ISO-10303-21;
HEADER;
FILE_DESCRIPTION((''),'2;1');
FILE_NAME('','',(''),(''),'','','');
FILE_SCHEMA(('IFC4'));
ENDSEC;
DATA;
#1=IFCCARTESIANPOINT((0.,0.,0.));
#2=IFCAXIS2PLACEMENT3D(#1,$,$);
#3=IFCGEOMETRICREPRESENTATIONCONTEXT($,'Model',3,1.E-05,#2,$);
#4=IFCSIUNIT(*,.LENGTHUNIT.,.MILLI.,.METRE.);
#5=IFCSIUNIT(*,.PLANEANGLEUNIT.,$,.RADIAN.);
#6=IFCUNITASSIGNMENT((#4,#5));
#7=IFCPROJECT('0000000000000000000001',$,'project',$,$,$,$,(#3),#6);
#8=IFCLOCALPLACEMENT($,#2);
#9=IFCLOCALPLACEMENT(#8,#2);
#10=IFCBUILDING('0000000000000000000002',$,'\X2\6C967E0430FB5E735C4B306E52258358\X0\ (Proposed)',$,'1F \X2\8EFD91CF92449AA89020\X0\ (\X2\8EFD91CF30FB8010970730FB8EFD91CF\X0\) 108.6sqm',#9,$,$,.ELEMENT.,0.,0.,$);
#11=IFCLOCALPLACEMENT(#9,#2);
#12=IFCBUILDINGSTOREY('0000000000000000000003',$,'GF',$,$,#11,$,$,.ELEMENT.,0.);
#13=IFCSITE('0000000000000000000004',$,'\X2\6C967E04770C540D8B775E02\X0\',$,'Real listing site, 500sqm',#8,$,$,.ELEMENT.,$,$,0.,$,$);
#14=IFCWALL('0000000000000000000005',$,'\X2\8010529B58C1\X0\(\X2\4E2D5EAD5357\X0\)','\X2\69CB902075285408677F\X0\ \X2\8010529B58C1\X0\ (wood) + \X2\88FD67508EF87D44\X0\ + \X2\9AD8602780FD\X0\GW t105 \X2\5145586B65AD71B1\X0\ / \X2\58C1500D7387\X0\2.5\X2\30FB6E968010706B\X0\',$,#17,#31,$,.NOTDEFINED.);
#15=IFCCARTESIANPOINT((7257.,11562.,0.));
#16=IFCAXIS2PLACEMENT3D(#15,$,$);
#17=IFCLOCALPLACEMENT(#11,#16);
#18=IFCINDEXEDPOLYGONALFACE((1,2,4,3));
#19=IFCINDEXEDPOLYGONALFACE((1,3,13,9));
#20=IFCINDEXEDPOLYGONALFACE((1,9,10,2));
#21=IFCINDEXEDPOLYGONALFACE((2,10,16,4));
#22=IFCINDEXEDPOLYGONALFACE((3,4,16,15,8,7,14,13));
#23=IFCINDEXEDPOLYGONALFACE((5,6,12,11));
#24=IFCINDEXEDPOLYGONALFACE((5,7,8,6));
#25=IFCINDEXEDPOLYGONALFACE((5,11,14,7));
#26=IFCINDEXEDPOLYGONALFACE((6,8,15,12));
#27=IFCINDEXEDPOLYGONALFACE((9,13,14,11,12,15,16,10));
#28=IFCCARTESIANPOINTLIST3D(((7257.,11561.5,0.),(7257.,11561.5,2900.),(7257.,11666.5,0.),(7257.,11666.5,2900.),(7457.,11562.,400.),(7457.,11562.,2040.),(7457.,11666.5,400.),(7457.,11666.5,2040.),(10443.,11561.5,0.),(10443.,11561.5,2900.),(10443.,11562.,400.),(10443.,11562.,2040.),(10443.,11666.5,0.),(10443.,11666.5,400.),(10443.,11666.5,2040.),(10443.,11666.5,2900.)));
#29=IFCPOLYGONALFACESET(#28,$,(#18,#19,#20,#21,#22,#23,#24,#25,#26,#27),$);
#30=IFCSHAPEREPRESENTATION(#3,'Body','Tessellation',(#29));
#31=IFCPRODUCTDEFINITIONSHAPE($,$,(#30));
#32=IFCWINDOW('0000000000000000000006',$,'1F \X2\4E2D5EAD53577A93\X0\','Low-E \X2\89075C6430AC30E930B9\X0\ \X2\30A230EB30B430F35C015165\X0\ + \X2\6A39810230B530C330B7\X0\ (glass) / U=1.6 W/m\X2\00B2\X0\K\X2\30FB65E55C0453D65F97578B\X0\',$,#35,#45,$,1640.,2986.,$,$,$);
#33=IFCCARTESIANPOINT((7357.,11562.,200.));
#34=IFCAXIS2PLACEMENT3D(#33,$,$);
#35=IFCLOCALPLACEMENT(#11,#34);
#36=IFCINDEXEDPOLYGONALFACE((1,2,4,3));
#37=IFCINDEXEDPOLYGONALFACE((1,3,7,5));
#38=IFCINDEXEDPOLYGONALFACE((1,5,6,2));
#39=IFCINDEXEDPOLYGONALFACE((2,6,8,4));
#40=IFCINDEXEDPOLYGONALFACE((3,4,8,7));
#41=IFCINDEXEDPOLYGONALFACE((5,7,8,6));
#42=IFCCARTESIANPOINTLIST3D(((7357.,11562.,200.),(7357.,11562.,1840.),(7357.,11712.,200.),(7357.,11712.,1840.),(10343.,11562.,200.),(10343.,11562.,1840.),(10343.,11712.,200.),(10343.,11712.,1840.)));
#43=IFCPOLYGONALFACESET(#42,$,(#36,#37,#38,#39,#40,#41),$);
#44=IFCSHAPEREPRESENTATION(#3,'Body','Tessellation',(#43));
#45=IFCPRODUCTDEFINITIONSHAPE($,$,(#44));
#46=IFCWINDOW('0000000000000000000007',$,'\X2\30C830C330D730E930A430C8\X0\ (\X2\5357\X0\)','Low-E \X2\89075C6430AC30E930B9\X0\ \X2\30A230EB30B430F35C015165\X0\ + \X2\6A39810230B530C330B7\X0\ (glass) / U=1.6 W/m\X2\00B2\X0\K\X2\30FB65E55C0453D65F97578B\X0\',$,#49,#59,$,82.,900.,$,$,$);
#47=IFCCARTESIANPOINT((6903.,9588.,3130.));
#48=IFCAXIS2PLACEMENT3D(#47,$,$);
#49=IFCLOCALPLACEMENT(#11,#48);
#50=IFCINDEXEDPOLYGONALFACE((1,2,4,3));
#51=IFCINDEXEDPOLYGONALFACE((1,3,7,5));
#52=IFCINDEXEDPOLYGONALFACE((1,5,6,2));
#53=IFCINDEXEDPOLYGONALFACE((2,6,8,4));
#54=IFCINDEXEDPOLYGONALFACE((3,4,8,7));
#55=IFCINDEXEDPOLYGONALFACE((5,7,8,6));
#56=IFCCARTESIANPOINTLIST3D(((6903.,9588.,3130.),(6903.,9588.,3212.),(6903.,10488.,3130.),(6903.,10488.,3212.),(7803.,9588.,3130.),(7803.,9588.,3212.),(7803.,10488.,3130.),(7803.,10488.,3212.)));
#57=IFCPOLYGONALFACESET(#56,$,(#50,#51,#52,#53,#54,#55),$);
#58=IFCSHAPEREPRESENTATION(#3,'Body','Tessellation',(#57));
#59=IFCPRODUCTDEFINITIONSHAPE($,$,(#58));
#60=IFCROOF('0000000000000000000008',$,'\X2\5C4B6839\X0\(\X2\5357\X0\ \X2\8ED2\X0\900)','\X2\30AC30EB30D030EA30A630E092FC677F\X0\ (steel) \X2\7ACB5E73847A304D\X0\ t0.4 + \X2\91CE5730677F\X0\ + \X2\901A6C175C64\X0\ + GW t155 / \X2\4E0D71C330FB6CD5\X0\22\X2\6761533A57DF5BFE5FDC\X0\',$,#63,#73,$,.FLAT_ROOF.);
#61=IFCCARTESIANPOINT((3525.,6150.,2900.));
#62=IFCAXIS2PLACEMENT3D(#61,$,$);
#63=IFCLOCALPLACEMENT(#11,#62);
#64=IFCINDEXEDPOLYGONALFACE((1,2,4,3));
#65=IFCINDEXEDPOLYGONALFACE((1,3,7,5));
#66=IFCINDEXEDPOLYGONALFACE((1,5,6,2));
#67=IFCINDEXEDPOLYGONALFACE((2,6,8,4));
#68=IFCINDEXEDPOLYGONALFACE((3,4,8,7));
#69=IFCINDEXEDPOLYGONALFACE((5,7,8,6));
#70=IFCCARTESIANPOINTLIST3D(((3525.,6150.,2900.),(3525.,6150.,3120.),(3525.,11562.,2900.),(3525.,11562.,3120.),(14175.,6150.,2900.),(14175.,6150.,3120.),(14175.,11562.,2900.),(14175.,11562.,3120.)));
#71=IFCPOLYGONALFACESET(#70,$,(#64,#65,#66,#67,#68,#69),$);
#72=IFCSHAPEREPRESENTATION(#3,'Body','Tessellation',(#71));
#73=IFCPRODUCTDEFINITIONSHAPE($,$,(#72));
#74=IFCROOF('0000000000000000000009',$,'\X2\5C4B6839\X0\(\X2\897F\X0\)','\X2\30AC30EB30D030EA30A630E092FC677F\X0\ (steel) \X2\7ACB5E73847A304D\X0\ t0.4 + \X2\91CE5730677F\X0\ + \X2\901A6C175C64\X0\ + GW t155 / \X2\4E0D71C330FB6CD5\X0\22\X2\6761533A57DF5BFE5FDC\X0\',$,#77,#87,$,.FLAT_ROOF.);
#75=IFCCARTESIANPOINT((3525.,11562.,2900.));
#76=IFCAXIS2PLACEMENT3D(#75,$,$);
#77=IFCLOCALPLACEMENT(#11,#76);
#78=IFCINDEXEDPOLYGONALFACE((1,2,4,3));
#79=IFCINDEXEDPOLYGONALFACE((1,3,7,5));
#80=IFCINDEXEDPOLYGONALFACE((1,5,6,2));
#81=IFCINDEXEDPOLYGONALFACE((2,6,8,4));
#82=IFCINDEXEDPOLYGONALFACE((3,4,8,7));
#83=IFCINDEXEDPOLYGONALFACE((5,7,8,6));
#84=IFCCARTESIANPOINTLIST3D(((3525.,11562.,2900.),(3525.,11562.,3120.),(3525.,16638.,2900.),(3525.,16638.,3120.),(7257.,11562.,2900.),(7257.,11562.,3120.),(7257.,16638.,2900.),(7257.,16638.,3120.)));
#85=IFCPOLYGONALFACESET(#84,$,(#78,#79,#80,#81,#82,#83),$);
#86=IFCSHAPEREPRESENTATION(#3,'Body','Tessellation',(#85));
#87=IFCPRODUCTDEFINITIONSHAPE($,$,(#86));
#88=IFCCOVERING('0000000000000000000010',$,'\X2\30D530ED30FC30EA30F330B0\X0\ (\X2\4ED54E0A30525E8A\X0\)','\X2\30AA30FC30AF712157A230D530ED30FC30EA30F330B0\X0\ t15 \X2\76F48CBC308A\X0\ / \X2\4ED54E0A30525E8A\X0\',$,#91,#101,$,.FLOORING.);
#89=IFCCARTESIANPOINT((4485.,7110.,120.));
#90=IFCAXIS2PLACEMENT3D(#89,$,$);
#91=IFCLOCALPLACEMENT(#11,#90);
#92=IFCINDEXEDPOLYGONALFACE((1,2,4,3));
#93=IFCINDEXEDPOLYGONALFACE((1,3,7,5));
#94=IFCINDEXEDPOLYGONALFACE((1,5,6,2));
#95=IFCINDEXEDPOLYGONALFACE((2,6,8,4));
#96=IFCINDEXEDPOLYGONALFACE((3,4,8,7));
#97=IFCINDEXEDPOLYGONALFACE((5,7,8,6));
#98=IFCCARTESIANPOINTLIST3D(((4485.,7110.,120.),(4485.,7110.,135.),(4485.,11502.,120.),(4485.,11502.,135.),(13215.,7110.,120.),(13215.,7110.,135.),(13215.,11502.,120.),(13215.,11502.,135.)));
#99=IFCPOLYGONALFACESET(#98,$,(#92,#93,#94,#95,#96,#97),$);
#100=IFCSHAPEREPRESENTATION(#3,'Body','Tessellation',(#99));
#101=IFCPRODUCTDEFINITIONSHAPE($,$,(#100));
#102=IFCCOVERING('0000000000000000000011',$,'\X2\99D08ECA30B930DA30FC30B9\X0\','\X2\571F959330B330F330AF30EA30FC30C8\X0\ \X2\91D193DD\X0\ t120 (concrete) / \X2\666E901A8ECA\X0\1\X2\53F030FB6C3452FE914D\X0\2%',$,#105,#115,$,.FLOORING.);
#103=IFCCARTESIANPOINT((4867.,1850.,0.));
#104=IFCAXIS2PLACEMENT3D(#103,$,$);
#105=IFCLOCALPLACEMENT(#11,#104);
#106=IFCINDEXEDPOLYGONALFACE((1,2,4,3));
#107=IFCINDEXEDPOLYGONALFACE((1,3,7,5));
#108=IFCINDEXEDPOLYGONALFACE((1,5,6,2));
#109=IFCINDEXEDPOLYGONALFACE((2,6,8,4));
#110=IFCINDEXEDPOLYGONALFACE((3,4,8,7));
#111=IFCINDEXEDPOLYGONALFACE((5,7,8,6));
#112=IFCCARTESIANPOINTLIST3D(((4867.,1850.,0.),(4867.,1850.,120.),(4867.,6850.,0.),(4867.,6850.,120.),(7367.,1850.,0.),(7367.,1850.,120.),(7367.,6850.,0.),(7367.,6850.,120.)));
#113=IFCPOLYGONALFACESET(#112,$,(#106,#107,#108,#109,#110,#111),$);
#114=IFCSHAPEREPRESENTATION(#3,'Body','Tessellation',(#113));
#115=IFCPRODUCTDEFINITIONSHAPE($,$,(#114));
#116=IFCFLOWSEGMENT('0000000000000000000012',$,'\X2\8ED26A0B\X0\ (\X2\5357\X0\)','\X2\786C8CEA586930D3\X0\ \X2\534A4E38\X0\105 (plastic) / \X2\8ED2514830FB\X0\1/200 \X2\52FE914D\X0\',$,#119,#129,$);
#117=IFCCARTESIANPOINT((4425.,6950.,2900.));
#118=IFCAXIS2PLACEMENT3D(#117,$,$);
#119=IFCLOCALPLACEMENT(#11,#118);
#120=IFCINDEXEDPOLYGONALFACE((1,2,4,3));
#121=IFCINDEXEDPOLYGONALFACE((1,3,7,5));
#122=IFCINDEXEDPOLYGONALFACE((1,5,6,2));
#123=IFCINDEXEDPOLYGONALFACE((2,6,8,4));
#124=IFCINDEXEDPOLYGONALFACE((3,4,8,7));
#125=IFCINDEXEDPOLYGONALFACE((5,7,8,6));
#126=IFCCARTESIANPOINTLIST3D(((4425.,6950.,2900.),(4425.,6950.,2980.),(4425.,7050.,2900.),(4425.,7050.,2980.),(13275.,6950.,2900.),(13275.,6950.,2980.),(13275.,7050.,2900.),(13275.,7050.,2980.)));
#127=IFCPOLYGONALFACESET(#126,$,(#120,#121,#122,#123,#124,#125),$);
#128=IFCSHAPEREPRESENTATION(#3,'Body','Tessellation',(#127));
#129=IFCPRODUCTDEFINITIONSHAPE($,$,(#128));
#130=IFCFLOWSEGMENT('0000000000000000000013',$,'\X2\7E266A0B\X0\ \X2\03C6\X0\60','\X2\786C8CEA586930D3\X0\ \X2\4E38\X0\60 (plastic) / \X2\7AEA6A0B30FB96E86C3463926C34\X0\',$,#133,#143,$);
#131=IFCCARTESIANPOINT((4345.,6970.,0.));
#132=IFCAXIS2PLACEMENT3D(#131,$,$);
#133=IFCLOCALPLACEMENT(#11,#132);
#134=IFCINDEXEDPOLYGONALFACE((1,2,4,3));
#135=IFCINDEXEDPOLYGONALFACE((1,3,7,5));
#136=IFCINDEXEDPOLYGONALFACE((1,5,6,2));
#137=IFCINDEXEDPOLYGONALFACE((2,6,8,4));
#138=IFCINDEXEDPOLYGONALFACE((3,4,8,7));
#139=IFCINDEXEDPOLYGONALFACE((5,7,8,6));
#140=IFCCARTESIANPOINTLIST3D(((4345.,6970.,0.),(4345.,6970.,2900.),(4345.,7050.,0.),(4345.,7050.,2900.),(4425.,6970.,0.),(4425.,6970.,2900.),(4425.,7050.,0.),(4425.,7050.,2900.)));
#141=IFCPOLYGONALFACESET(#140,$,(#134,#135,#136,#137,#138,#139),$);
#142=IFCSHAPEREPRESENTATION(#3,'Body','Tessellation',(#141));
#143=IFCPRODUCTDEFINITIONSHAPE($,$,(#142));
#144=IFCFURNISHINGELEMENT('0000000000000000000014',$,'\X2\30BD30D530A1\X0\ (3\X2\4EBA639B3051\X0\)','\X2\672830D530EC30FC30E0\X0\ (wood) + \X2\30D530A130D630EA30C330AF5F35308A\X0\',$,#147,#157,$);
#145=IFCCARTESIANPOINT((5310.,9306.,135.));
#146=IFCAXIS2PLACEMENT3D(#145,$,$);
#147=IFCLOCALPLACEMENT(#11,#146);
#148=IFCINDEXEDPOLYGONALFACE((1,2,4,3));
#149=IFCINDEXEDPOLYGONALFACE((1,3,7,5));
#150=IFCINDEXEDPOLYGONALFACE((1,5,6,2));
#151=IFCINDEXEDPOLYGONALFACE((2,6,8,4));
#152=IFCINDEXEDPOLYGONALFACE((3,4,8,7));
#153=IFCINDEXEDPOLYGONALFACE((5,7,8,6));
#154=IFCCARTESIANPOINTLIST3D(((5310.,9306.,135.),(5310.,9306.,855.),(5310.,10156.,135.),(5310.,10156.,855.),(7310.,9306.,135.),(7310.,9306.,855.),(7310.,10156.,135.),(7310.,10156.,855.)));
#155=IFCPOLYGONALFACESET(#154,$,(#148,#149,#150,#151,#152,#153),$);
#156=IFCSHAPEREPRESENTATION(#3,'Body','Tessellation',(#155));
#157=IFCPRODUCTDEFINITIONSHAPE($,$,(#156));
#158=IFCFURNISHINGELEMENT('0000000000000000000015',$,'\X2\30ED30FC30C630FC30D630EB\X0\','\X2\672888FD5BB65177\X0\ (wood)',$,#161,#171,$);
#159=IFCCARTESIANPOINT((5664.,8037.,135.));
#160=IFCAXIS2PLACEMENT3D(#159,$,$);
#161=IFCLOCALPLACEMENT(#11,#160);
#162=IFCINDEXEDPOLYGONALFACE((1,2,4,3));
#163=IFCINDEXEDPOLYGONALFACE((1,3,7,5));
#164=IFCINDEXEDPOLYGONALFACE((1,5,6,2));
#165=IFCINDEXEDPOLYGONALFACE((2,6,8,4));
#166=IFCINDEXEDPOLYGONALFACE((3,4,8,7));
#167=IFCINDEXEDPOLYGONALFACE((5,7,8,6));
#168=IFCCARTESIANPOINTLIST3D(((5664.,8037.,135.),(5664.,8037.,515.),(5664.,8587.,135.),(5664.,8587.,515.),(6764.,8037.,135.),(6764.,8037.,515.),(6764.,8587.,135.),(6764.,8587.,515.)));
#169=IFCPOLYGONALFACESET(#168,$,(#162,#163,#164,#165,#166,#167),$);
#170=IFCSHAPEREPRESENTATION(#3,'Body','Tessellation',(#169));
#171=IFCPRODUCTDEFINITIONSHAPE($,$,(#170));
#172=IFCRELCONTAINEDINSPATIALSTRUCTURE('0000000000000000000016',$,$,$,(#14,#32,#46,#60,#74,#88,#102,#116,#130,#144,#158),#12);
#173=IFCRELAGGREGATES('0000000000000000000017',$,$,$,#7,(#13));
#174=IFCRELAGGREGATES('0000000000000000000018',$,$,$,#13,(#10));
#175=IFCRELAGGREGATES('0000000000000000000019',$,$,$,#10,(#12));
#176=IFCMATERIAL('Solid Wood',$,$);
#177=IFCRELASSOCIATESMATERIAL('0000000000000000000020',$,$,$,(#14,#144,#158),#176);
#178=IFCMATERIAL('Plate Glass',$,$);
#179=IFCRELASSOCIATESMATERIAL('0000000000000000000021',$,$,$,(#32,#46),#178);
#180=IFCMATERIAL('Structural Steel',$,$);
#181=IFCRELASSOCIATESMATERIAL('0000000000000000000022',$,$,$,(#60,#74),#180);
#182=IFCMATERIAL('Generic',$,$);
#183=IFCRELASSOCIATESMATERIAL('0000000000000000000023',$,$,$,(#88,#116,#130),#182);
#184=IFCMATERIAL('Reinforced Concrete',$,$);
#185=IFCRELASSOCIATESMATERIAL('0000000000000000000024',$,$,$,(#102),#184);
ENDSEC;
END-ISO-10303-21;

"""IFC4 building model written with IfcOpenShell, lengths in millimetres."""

from ifc_helpers import new_model, si_unit, frame, frame_2d, origin, place, context, project, spatial, rectangle, extrude, material, element, fill, save


model = new_model("IFC4")

# Units and contexts
model_context = context("Model", 3, precision=1e-05, world=origin())
ifc_project = project(units=[si_unit("LENGTHUNIT", "METRE", prefix="MILLI"), si_unit("PLANEANGLEUNIT", "RADIAN")], contexts=[model_context])

# Site, building, storey
site_placement = place(None, origin())
site = spatial("IfcSite", under=ifc_project, at=site_placement, Name="沖縄県名護市", ObjectType="Real listing site, 500sqm", CompositionType="ELEMENT", RefElevation=0.0)
building_placement = place(site_placement, origin())
building = spatial("IfcBuilding", under=site, at=building_placement, Name="沖縄・平屋の別荘 (Proposed)", ObjectType="1F 軽量鉄骨造 (軽量・耐震・軽量) 108.6sqm", CompositionType="ELEMENT", ElevationOfRefHeight=0.0, ElevationOfTerrain=0.0)
storey_placement = place(building_placement, origin())
storey = spatial("IfcBuildingStorey", under=building, at=storey_placement, Name="GF", CompositionType="ELEMENT", Elevation=0.0)

# Shared definitions
ifc_material_1 = material(Name="Solid Wood")

# Shared definitions
ifc_material_2 = material(Name="Reinforced Concrete")

# Shared definitions
ifc_material_3 = material(Name="Plate Glass")

# Wall, opening, window
wall_1_placement = place(storey_placement, frame((7257.0, 11562.0, 0.0)))
wall_1 = element("IfcWall", 1, at=wall_1_placement, inside=storey, material=ifc_material_1, Name="耐力壁(中庭南)", Description="構造用合板 耐力壁 (wood) + 製材軸組 + 高性能GW t105 充填断熱 / 壁倍率2.5・準耐火", PredefinedType="NOTDEFINED", context=model_context, shape_type="SweptSolid", body=[
    extrude(rectangle(XDim=3186.0, YDim=105.0, at=frame_2d((1593.0, 52.0))), frame((7257.0, 11562.0, 0.0)), (0.0, 0.0, 1.0), 2900.0),
])
opening_1_placement = place(storey_placement, frame((7357.0, 11562.0, 200.0)))
opening_1 = element("IfcOpeningElement", 2, at=opening_1_placement, cuts=wall_1, PredefinedType="NOTDEFINED", context=model_context, shape_type="SweptSolid", body=[
    extrude(rectangle(XDim=2986.0, YDim=150.0, at=frame_2d((1493.0, 75.0))), frame((7357.0, 11562.0, 200.0)), (0.0, 0.0, 1.0), 1640.0),
])
window_1_placement = place(storey_placement, frame((7357.0, 11562.0, 200.0)))
window_1 = element("IfcWindow", 3, at=window_1_placement, inside=storey, material=ifc_material_3, Name="1F 中庭南窓", Description="Low-E 複層ガラス アルゴン封入 + 樹脂サッシ (glass) / U=1.6 W/m²K・日射取得型", OverallHeight=1640.0, OverallWidth=2986.0, context=model_context, shape_type="SweptSolid", body=[
    extrude(rectangle(XDim=2986.0, YDim=150.0, at=frame_2d((1493.0, 75.0))), frame((7357.0, 11562.0, 200.0)), (0.0, 0.0, 1.0), 1640.0),
])
fill(opening_1, window_1)

# Window
window_2_placement = place(storey_placement, frame((6903.0, 9588.0, 3130.0)))
element("IfcWindow", 4, at=window_2_placement, inside=storey, material=ifc_material_3, Name="トップライト (南)", Description="Low-E 複層ガラス アルゴン封入 + 樹脂サッシ (glass) / U=1.6 W/m²K・日射取得型", OverallHeight=82.0, OverallWidth=900.0, context=model_context, shape_type="SweptSolid", body=[
    extrude(rectangle(XDim=900.0, YDim=900.0, at=frame_2d((450.0, 450.0))), frame((6903.0, 9588.0, 3130.0)), (0.0, 0.0, 1.0), 82.0),
])

# Roofs
ifc_material_4 = material(Name="Structural Steel")
roof_1_placement = place(storey_placement, frame((3525.0, 6150.0, 2900.0)))
element("IfcRoof", 5, at=roof_1_placement, inside=storey, material=ifc_material_4, Name="屋根(南 軒900)", Description="ガルバリウム鋼板 (steel) 立平葺き t0.4 + 野地板 + 通気層 + GW t155 / 不燃・法22条区域対応", PredefinedType="FLAT_ROOF", context=model_context, shape_type="SweptSolid", body=[
    extrude(rectangle(XDim=10650.0, YDim=5412.0, at=frame_2d((5325.0, 2706.0))), frame((3525.0, 6150.0, 2900.0)), (0.0, 0.0, 1.0), 220.0),
])
roof_2_placement = place(storey_placement, frame((3525.0, 11562.0, 2900.0)))
element("IfcRoof", 6, at=roof_2_placement, inside=storey, material=ifc_material_4, Name="屋根(西)", Description="ガルバリウム鋼板 (steel) 立平葺き t0.4 + 野地板 + 通気層 + GW t155 / 不燃・法22条区域対応", PredefinedType="FLAT_ROOF", context=model_context, shape_type="SweptSolid", body=[
    extrude(rectangle(XDim=3732.0, YDim=5076.0, at=frame_2d((1866.0, 2538.0))), frame((3525.0, 11562.0, 2900.0)), (0.0, 0.0, 1.0), 220.0),
])

# Coverings
ifc_material_5 = material(Name="Generic")
covering_1_placement = place(storey_placement, frame((4485.0, 7110.0, 120.0)))
element("IfcCovering", 7, at=covering_1_placement, inside=storey, material=ifc_material_5, Name="フローリング (仕上げ床)", Description="オーク無垢フローリング t15 直貼り / 仕上げ床", PredefinedType="FLOORING", context=model_context, shape_type="SweptSolid", body=[
    extrude(rectangle(XDim=8730.0, YDim=4392.0, at=frame_2d((4365.0, 2196.0))), frame((4485.0, 7110.0, 120.0)), (0.0, 0.0, 1.0), 15.0),
])
covering_2_placement = place(storey_placement, frame((4867.0, 1850.0, 0.0)))
element("IfcCovering", 8, at=covering_2_placement, inside=storey, material=ifc_material_2, Name="駐車スペース", Description="土間コンクリート 金鏝 t120 (concrete) / 普通車1台・水勾配2%", PredefinedType="FLOORING", context=model_context, shape_type="SweptSolid", body=[
    extrude(rectangle(XDim=2500.0, YDim=5000.0, at=frame_2d((1250.0, 2500.0))), frame((4867.0, 1850.0, 0.0)), (0.0, 0.0, 1.0), 120.0),
])

# Flow segments
flow_segment_1_placement = place(storey_placement, frame((4425.0, 6950.0, 2900.0)))
element("IfcFlowSegment", 9, at=flow_segment_1_placement, inside=storey, material=ifc_material_5, Name="軒樋 (南)", Description="硬質塩ビ 半丸105 (plastic) / 軒先・1/200 勾配", context=model_context, shape_type="SweptSolid", body=[
    extrude(rectangle(XDim=8850.0, YDim=100.0, at=frame_2d((4425.0, 50.0))), frame((4425.0, 6950.0, 2900.0)), (0.0, 0.0, 1.0), 80.0),
])
flow_segment_2_placement = place(storey_placement, frame((4345.0, 6970.0, 0.0)))
element("IfcFlowSegment", 10, at=flow_segment_2_placement, inside=storey, material=ifc_material_5, Name="縦樋 φ60", Description="硬質塩ビ 丸60 (plastic) / 竪樋・雨水排水", context=model_context, shape_type="SweptSolid", body=[
    extrude(rectangle(XDim=80.0, YDim=80.0, at=frame_2d((40.0, 40.0))), frame((4345.0, 6970.0, 0.0)), (0.0, 0.0, 1.0), 2900.0),
])

# Furnishing elements
furnishing_1_placement = place(storey_placement, frame((5310.0, 9306.0, 135.0)))
element("IfcFurnishingElement", 11, at=furnishing_1_placement, inside=storey, material=ifc_material_1, Name="ソファ (3人掛け)", Description="木フレーム (wood) + ファブリック張り", context=model_context, shape_type="SweptSolid", body=[
    extrude(rectangle(XDim=2000.0, YDim=850.0, at=frame_2d((1000.0, 425.0))), frame((5310.0, 9306.0, 135.0)), (0.0, 0.0, 1.0), 720.0),
])
furnishing_2_placement = place(storey_placement, frame((5664.0, 8037.0, 135.0)))
element("IfcFurnishingElement", 12, at=furnishing_2_placement, inside=storey, material=ifc_material_1, Name="ローテーブル", Description="木製家具 (wood)", context=model_context, shape_type="SweptSolid", body=[
    extrude(rectangle(XDim=1100.0, YDim=550.0, at=frame_2d((550.0, 275.0))), frame((5664.0, 8037.0, 135.0)), (0.0, 0.0, 1.0), 380.0),
])

save(model, "model.ifc")
